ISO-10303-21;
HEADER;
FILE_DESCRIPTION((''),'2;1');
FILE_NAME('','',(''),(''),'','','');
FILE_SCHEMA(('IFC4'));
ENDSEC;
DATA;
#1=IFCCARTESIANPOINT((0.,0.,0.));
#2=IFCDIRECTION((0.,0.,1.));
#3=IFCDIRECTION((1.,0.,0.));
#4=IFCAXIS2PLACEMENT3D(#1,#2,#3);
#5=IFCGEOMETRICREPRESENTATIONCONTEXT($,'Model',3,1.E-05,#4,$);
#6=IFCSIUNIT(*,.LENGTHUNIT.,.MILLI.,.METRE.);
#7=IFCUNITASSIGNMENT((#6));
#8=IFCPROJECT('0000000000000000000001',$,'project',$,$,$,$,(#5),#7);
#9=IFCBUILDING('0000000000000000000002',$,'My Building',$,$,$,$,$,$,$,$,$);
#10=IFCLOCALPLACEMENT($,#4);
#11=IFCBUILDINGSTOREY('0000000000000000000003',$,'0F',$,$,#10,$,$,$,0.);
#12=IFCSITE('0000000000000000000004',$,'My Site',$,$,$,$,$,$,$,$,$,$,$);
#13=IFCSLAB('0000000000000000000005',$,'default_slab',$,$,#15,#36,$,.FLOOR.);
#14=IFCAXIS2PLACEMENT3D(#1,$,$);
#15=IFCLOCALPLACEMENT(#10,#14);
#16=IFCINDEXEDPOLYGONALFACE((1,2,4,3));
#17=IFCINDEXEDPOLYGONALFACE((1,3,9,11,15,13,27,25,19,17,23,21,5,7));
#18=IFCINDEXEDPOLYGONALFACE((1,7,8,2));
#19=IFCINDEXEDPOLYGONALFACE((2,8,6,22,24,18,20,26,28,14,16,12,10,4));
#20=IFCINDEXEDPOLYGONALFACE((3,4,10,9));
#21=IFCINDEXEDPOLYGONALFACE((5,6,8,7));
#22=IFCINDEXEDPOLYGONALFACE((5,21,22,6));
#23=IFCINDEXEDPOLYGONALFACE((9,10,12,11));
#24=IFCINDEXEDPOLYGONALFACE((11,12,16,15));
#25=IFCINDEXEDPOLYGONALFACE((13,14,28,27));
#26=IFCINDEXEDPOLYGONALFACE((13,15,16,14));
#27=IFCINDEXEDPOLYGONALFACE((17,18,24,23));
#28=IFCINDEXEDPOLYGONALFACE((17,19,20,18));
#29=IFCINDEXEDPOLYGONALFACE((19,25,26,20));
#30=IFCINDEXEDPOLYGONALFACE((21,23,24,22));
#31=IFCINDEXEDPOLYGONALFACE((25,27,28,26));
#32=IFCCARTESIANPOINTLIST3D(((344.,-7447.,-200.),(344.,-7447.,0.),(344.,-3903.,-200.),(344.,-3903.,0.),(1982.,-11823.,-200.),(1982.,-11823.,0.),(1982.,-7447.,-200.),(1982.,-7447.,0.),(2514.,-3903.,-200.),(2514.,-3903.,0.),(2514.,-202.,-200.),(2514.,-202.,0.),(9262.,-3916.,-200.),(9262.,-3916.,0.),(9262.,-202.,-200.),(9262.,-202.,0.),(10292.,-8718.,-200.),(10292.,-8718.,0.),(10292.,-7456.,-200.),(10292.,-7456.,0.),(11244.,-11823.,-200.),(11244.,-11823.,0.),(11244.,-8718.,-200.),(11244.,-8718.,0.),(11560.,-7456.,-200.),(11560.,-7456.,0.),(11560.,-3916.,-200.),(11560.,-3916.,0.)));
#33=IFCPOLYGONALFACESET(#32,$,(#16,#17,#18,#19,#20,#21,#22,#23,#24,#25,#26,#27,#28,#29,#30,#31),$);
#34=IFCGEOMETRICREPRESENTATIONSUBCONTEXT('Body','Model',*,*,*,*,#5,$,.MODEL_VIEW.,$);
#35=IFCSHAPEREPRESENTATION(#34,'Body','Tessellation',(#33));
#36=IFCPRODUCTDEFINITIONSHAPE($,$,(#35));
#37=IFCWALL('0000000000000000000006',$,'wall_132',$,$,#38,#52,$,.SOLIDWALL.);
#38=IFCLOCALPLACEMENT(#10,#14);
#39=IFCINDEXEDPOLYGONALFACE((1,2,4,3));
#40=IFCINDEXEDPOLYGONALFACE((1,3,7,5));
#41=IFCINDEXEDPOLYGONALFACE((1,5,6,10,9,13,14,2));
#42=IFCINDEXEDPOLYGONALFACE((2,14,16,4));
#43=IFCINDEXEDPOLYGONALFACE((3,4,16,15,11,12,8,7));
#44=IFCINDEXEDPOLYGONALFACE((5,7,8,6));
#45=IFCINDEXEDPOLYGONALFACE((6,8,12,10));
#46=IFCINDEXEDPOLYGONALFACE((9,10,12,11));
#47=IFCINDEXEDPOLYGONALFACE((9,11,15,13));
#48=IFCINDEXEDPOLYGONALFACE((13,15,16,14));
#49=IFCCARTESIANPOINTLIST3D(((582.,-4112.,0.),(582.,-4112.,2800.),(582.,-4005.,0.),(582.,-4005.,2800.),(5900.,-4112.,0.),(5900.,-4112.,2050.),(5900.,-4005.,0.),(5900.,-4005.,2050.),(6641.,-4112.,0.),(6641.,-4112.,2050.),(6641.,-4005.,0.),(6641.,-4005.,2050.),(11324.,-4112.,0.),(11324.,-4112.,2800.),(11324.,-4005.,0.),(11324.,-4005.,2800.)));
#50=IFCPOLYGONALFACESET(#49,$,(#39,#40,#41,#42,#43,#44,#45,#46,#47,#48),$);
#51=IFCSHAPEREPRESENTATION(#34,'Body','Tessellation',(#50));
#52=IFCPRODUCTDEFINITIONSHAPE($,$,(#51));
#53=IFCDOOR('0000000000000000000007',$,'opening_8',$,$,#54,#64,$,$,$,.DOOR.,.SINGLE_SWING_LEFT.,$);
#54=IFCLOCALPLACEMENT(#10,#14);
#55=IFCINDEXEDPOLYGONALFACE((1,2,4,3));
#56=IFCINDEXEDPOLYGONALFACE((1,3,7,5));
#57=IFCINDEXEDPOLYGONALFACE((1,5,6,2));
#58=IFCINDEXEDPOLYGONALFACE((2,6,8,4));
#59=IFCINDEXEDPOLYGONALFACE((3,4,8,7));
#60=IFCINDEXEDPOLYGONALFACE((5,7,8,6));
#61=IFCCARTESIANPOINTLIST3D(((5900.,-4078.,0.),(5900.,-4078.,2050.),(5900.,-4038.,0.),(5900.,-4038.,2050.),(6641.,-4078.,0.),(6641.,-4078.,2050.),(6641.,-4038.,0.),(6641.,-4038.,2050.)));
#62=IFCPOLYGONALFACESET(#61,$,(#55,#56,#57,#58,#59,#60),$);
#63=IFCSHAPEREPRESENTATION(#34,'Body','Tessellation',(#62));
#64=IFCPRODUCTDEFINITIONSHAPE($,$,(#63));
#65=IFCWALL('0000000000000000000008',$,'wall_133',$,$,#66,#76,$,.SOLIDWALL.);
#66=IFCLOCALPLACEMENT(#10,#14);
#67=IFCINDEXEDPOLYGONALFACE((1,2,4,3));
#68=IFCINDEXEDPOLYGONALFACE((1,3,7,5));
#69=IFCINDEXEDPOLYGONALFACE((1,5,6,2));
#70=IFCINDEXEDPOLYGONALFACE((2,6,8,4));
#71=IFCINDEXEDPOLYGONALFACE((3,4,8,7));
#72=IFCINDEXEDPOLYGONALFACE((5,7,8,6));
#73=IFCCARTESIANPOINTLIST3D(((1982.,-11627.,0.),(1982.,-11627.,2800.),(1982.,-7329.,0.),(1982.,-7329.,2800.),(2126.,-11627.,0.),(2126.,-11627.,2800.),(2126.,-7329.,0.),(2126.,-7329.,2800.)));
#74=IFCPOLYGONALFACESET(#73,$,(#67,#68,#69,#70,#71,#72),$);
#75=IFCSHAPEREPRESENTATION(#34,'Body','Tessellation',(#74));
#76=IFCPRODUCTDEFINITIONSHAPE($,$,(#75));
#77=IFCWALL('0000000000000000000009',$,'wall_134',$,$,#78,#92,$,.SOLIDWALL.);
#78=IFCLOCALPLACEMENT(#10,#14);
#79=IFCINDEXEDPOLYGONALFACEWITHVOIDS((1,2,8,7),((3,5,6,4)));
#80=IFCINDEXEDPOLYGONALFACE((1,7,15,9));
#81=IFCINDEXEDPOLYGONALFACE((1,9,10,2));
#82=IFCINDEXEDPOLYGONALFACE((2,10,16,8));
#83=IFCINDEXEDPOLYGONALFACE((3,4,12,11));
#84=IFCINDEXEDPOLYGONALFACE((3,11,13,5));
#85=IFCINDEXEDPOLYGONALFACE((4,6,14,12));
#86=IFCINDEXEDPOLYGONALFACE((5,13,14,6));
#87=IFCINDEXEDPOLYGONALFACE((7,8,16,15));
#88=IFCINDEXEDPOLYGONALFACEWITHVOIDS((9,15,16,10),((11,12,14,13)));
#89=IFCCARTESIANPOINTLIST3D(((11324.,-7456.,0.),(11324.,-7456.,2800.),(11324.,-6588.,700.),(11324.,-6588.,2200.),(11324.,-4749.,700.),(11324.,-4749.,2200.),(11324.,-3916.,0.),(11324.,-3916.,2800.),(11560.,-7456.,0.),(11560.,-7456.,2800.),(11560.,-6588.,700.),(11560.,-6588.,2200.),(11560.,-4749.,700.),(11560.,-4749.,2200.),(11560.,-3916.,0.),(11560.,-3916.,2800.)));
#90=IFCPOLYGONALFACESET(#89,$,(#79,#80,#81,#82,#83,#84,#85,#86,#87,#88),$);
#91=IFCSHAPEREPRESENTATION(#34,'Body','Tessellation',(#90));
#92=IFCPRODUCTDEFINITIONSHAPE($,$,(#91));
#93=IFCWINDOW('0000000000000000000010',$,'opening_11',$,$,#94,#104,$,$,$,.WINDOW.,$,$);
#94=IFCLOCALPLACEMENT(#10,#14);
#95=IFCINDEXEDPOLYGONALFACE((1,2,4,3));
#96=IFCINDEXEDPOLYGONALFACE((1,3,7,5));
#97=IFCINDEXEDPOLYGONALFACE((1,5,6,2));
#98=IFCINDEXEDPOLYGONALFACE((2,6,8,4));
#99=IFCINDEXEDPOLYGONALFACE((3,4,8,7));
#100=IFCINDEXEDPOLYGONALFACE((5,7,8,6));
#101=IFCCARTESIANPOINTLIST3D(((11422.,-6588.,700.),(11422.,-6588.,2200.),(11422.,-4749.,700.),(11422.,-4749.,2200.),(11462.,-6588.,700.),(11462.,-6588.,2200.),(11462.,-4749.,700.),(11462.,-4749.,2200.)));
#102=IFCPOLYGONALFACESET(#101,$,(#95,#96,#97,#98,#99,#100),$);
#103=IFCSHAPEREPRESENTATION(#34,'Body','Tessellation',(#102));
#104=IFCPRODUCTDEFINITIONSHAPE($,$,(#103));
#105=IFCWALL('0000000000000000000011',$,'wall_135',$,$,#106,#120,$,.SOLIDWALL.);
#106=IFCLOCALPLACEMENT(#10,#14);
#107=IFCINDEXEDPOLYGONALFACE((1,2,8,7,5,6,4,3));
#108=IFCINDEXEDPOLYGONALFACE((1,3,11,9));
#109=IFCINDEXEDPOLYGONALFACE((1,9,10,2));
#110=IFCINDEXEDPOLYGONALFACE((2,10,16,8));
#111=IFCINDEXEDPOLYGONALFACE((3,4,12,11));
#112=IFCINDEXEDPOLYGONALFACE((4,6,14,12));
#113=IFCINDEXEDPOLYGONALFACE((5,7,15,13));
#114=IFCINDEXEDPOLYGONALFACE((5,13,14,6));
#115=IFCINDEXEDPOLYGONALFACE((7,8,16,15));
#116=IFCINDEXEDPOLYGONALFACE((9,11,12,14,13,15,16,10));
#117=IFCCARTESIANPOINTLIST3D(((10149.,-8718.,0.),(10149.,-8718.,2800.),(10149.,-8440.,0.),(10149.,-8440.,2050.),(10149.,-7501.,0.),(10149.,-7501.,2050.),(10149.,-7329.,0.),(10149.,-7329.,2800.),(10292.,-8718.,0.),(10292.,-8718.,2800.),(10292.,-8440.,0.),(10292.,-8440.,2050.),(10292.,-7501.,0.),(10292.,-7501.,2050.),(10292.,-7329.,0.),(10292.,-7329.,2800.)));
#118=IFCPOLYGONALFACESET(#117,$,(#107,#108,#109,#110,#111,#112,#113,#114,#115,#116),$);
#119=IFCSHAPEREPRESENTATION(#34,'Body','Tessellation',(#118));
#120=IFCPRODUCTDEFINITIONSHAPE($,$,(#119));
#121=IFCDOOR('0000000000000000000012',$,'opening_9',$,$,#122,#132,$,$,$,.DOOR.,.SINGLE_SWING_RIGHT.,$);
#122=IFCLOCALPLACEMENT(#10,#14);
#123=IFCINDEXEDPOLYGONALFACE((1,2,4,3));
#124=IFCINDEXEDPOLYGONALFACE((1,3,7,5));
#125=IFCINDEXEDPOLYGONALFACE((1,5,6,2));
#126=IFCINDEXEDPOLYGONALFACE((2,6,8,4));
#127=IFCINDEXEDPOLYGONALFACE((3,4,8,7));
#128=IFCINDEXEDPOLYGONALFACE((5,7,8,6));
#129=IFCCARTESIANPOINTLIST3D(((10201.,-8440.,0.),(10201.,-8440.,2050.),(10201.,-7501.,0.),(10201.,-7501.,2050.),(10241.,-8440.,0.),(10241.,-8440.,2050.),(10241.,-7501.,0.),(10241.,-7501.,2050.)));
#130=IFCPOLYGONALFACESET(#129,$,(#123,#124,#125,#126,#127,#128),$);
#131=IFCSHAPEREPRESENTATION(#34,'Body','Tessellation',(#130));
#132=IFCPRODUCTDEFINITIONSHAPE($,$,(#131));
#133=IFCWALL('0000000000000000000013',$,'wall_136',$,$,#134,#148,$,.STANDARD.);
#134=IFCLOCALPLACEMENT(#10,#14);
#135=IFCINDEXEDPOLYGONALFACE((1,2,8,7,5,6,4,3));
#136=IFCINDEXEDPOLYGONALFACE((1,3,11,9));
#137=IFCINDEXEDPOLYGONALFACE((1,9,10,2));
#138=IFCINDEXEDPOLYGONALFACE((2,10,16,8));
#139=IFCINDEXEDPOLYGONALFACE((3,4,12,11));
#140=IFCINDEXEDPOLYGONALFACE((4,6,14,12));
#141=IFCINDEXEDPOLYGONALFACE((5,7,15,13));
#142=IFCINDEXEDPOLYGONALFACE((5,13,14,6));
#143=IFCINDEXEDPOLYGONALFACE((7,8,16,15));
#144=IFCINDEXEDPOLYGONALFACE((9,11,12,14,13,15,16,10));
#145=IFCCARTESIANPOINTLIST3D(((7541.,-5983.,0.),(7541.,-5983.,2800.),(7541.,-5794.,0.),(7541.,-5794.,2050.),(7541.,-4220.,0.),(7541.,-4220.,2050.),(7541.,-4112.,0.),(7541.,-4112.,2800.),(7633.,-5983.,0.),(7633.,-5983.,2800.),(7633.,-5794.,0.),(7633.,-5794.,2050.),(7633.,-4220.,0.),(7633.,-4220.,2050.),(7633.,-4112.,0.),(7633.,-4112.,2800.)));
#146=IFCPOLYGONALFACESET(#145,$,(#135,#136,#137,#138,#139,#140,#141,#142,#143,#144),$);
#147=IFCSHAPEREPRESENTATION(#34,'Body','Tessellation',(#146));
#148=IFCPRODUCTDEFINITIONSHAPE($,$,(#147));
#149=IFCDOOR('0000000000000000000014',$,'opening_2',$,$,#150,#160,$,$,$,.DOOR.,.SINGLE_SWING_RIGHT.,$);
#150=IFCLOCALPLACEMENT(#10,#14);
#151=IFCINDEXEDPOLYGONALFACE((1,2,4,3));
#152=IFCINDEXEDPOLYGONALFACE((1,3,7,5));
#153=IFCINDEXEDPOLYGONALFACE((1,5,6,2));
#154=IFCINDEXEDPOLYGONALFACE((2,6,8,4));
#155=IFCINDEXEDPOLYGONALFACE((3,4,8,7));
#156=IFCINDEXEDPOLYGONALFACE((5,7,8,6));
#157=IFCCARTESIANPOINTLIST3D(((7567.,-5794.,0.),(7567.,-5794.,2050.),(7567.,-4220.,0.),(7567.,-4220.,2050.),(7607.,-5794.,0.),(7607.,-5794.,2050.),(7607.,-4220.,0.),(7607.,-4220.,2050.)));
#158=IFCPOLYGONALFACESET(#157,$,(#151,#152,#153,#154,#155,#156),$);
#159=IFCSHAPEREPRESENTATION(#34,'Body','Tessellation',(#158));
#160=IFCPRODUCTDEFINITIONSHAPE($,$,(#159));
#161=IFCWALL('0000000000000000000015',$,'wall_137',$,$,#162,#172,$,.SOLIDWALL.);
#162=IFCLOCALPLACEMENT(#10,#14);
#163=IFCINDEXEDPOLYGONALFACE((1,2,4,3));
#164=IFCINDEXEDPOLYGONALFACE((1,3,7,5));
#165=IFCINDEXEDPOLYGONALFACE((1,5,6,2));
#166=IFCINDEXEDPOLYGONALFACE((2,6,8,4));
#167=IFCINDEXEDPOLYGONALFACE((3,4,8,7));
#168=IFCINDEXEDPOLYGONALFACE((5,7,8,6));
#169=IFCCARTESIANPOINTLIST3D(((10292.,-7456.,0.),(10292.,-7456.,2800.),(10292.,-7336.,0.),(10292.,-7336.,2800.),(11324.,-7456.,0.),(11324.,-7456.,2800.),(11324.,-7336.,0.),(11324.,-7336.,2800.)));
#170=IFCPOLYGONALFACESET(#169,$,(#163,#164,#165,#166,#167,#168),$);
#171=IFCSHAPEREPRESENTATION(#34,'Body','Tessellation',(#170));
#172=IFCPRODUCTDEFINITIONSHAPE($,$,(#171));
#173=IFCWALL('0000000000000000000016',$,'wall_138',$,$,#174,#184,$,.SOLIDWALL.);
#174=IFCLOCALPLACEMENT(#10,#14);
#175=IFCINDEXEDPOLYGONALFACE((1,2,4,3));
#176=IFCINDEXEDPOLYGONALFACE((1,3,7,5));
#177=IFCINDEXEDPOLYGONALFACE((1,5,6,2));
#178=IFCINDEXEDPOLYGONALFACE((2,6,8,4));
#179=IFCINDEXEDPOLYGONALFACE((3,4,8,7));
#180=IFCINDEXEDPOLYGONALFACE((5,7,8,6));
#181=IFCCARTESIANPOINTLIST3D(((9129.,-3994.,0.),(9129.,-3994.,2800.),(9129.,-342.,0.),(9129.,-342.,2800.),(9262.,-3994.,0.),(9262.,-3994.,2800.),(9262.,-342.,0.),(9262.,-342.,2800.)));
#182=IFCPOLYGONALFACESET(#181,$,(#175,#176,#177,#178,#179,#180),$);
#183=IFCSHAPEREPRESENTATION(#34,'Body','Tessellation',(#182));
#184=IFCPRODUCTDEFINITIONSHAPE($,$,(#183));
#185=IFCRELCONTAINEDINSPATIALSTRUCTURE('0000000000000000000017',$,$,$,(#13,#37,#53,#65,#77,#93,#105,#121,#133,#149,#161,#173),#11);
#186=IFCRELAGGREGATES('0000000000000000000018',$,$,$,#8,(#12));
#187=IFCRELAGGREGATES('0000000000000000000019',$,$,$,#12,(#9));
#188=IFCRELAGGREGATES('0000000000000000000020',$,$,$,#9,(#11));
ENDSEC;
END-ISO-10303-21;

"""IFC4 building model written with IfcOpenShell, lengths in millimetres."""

from ifc_helpers import new_model, si_unit, frame, origin_with_axes, place, context, subcontext, project, spatial, indexed_curve, outline, extrude, element, fill, save


model = new_model("IFC4")

# Units and contexts
model_context_1 = context("Model", 3, precision=1e-05, world=origin_with_axes())
body_context_1 = subcontext(model_context_1, "Body", "Model", "MODEL_VIEW")
ifc_project = project(units=[si_unit("LENGTHUNIT", "METRE", prefix="MILLI")], contexts=[model_context_1])

# Site, building, storey
site = spatial("IfcSite", under=ifc_project, Name="My Site")
building = spatial("IfcBuilding", under=site, Name="My Building")
storey_placement = place(None, origin_with_axes())
storey = spatial("IfcBuildingStorey", under=building, at=storey_placement, Name="0F", Elevation=0.0)

# Slab
slab_placement = place(storey_placement, origin_with_axes())
element("IfcSlab", 1, at=slab_placement, inside=storey, Name="default_slab", PredefinedType="FLOOR", context=body_context_1, shape_type="SweptSolid", body=[
    extrude(outline(indexed_curve([(344.0, -3903.0), (344.0, -7447.0), (1982.0, -7447.0), (1982.0, -11823.0), (11244.0, -11823.0), (11244.0, -8718.0), (10292.0, -8718.0), (10292.0, -7456.0), (11560.0, -7456.0), (11560.0, -3916.0), (9262.0, -3916.0), (9262.0, -202.0), (2514.0, -202.0), (2514.0, -3903.0), (344.0, -3903.0)])), None, (0.0, 0.0, -1.0), 200.0),
])

# Wall, opening, door
wall_1_placement = place(storey_placement, origin_with_axes())
wall_1 = element("IfcWall", 2, at=wall_1_placement, inside=storey, Name="wall_132", PredefinedType="SOLIDWALL", context=body_context_1, shape_type="SweptSolid", body=[
    extrude(outline(indexed_curve([(582.0, -4112.0), (11324.0, -4112.0), (11324.0, -4005.0), (582.0, -4005.0), (582.0, -4112.0)])), None, (0.0, 0.0, 1.0), 2800.0),
])
opening_1_placement = place(wall_1_placement, origin_with_axes())
opening_1 = element("IfcOpeningElement", 3, at=opening_1_placement, cuts=wall_1, ObjectType="Opening", context=body_context_1, shape_type="SweptSolid", body=[
    extrude(outline(indexed_curve([(6641.0, -4178.0), (6641.0, -3939.0), (5900.0, -3939.0), (5900.0, -4178.0), (6641.0, -4178.0)])), None, (0.0, 0.0, 1.0), 2050.0),
])
door_1_placement = place(opening_1_placement, origin_with_axes())
door_1 = element("IfcDoor", 4, at=door_1_placement, inside=storey, Name="opening_8", OperationType="SINGLE_SWING_LEFT", PredefinedType="DOOR", context=body_context_1, shape_type="SweptSolid", body=[
    extrude(outline(indexed_curve([(6641.0, -4078.0), (6641.0, -4038.0), (5900.0, -4038.0), (5900.0, -4078.0), (6641.0, -4078.0)])), None, (0.0, 0.0, 1.0), 2050.0),
])
fill(opening_1, door_1)

# Wall
wall_2_placement = place(storey_placement, origin_with_axes())
element("IfcWall", 5, at=wall_2_placement, inside=storey, Name="wall_133", PredefinedType="SOLIDWALL", context=body_context_1, shape_type="SweptSolid", body=[
    extrude(outline(indexed_curve([(1982.0, -7329.0), (1982.0, -11627.0), (2126.0, -11627.0), (2126.0, -7329.0), (1982.0, -7329.0)])), None, (0.0, 0.0, 1.0), 2800.0),
])

# Wall, opening, window
wall_3_placement = place(storey_placement, origin_with_axes())
wall_3 = element("IfcWall", 6, at=wall_3_placement, inside=storey, Name="wall_134", PredefinedType="SOLIDWALL", context=body_context_1, shape_type="SweptSolid", body=[
    extrude(outline(indexed_curve([(11324.0, -3916.0), (11324.0, -7456.0), (11560.0, -7456.0), (11560.0, -3916.0), (11324.0, -3916.0)])), None, (0.0, 0.0, 1.0), 2800.0),
])
opening_2_placement = place(wall_3_placement, origin_with_axes())
opening_2 = element("IfcOpeningElement", 7, at=opening_2_placement, cuts=wall_3, ObjectType="Opening", context=body_context_1, shape_type="SweptSolid", body=[
    extrude(outline(indexed_curve([(11258.0, -6588.0), (11626.0, -6588.0), (11626.0, -4749.0), (11258.0, -4749.0), (11258.0, -6588.0)])), frame((0.0, 0.0, 700.0), z_axis=(0.0, 0.0, 1.0), x_axis=(1.0, 0.0, 0.0)), (0.0, 0.0, 1.0), 1500.0),
])
window_placement = place(opening_2_placement, origin_with_axes())
window = element("IfcWindow", 8, at=window_placement, inside=storey, Name="opening_11", PredefinedType="WINDOW", context=body_context_1, shape_type="SweptSolid", body=[
    extrude(outline(indexed_curve([(11422.0, -6588.0), (11462.0, -6588.0), (11462.0, -4749.0), (11422.0, -4749.0), (11422.0, -6588.0)])), frame((0.0, 0.0, 700.0), z_axis=(0.0, 0.0, 1.0), x_axis=(1.0, 0.0, 0.0)), (0.0, 0.0, 1.0), 1500.0),
])
fill(opening_2, window)

# Walls, openings, doors
wall_4_placement = place(storey_placement, origin_with_axes())
wall_4 = element("IfcWall", 9, at=wall_4_placement, inside=storey, Name="wall_135", PredefinedType="SOLIDWALL", context=body_context_1, shape_type="SweptSolid", body=[
    extrude(outline(indexed_curve([(10149.0, -7329.0), (10149.0, -8718.0), (10292.0, -8718.0), (10292.0, -7329.0), (10149.0, -7329.0)])), None, (0.0, 0.0, 1.0), 2800.0),
])
opening_3_placement = place(wall_4_placement, origin_with_axes())
opening_3 = element("IfcOpeningElement", 10, at=opening_3_placement, cuts=wall_4, ObjectType="Opening", context=body_context_1, shape_type="SweptSolid", body=[
    extrude(outline(indexed_curve([(10083.0, -8440.0), (10358.0, -8440.0), (10358.0, -7501.0), (10083.0, -7501.0), (10083.0, -8440.0)])), None, (0.0, 0.0, 1.0), 2050.0),
])
door_2_placement = place(opening_3_placement, origin_with_axes())
door_2 = element("IfcDoor", 11, at=door_2_placement, inside=storey, Name="opening_9", OperationType="SINGLE_SWING_RIGHT", PredefinedType="DOOR", context=body_context_1, shape_type="SweptSolid", body=[
    extrude(outline(indexed_curve([(10201.0, -8440.0), (10241.0, -8440.0), (10241.0, -7501.0), (10201.0, -7501.0), (10201.0, -8440.0)])), None, (0.0, 0.0, 1.0), 2050.0),
])
fill(opening_3, door_2)
wall_5_placement = place(storey_placement, origin_with_axes())
wall_5 = element("IfcWall", 12, at=wall_5_placement, inside=storey, Name="wall_136", PredefinedType="STANDARD", context=body_context_1, shape_type="SweptSolid", body=[
    extrude(outline(indexed_curve([(7541.0, -4112.0), (7541.0, -5983.0), (7633.0, -5983.0), (7633.0, -4112.0), (7541.0, -4112.0)])), None, (0.0, 0.0, 1.0), 2800.0),
])
opening_4_placement = place(wall_5_placement, origin_with_axes())
opening_4 = element("IfcOpeningElement", 13, at=opening_4_placement, cuts=wall_5, ObjectType="Opening", context=body_context_1, shape_type="SweptSolid", body=[
    extrude(outline(indexed_curve([(7475.0, -5794.0), (7699.0, -5794.0), (7699.0, -4220.0), (7475.0, -4220.0), (7475.0, -5794.0)])), None, (0.0, 0.0, 1.0), 2050.0),
])
door_3_placement = place(opening_4_placement, origin_with_axes())
door_3 = element("IfcDoor", 14, at=door_3_placement, inside=storey, Name="opening_2", OperationType="SINGLE_SWING_RIGHT", PredefinedType="DOOR", context=body_context_1, shape_type="SweptSolid", body=[
    extrude(outline(indexed_curve([(7567.0, -5794.0), (7607.0, -5794.0), (7607.0, -4220.0), (7567.0, -4220.0), (7567.0, -5794.0)])), None, (0.0, 0.0, 1.0), 2050.0),
])
fill(opening_4, door_3)

# Walls
wall_6_placement = place(storey_placement, origin_with_axes())
element("IfcWall", 15, at=wall_6_placement, inside=storey, Name="wall_137", PredefinedType="SOLIDWALL", context=body_context_1, shape_type="SweptSolid", body=[
    extrude(outline(indexed_curve([(10292.0, -7456.0), (11324.0, -7456.0), (11324.0, -7336.0), (10292.0, -7336.0), (10292.0, -7456.0)])), None, (0.0, 0.0, 1.0), 2800.0),
])
wall_7_placement = place(storey_placement, origin_with_axes())
element("IfcWall", 16, at=wall_7_placement, inside=storey, Name="wall_138", PredefinedType="SOLIDWALL", context=body_context_1, shape_type="SweptSolid", body=[
    extrude(outline(indexed_curve([(9129.0, -342.0), (9129.0, -3994.0), (9262.0, -3994.0), (9262.0, -342.0), (9129.0, -342.0)])), None, (0.0, 0.0, 1.0), 2800.0),
])

save(model, "model.ifc")
